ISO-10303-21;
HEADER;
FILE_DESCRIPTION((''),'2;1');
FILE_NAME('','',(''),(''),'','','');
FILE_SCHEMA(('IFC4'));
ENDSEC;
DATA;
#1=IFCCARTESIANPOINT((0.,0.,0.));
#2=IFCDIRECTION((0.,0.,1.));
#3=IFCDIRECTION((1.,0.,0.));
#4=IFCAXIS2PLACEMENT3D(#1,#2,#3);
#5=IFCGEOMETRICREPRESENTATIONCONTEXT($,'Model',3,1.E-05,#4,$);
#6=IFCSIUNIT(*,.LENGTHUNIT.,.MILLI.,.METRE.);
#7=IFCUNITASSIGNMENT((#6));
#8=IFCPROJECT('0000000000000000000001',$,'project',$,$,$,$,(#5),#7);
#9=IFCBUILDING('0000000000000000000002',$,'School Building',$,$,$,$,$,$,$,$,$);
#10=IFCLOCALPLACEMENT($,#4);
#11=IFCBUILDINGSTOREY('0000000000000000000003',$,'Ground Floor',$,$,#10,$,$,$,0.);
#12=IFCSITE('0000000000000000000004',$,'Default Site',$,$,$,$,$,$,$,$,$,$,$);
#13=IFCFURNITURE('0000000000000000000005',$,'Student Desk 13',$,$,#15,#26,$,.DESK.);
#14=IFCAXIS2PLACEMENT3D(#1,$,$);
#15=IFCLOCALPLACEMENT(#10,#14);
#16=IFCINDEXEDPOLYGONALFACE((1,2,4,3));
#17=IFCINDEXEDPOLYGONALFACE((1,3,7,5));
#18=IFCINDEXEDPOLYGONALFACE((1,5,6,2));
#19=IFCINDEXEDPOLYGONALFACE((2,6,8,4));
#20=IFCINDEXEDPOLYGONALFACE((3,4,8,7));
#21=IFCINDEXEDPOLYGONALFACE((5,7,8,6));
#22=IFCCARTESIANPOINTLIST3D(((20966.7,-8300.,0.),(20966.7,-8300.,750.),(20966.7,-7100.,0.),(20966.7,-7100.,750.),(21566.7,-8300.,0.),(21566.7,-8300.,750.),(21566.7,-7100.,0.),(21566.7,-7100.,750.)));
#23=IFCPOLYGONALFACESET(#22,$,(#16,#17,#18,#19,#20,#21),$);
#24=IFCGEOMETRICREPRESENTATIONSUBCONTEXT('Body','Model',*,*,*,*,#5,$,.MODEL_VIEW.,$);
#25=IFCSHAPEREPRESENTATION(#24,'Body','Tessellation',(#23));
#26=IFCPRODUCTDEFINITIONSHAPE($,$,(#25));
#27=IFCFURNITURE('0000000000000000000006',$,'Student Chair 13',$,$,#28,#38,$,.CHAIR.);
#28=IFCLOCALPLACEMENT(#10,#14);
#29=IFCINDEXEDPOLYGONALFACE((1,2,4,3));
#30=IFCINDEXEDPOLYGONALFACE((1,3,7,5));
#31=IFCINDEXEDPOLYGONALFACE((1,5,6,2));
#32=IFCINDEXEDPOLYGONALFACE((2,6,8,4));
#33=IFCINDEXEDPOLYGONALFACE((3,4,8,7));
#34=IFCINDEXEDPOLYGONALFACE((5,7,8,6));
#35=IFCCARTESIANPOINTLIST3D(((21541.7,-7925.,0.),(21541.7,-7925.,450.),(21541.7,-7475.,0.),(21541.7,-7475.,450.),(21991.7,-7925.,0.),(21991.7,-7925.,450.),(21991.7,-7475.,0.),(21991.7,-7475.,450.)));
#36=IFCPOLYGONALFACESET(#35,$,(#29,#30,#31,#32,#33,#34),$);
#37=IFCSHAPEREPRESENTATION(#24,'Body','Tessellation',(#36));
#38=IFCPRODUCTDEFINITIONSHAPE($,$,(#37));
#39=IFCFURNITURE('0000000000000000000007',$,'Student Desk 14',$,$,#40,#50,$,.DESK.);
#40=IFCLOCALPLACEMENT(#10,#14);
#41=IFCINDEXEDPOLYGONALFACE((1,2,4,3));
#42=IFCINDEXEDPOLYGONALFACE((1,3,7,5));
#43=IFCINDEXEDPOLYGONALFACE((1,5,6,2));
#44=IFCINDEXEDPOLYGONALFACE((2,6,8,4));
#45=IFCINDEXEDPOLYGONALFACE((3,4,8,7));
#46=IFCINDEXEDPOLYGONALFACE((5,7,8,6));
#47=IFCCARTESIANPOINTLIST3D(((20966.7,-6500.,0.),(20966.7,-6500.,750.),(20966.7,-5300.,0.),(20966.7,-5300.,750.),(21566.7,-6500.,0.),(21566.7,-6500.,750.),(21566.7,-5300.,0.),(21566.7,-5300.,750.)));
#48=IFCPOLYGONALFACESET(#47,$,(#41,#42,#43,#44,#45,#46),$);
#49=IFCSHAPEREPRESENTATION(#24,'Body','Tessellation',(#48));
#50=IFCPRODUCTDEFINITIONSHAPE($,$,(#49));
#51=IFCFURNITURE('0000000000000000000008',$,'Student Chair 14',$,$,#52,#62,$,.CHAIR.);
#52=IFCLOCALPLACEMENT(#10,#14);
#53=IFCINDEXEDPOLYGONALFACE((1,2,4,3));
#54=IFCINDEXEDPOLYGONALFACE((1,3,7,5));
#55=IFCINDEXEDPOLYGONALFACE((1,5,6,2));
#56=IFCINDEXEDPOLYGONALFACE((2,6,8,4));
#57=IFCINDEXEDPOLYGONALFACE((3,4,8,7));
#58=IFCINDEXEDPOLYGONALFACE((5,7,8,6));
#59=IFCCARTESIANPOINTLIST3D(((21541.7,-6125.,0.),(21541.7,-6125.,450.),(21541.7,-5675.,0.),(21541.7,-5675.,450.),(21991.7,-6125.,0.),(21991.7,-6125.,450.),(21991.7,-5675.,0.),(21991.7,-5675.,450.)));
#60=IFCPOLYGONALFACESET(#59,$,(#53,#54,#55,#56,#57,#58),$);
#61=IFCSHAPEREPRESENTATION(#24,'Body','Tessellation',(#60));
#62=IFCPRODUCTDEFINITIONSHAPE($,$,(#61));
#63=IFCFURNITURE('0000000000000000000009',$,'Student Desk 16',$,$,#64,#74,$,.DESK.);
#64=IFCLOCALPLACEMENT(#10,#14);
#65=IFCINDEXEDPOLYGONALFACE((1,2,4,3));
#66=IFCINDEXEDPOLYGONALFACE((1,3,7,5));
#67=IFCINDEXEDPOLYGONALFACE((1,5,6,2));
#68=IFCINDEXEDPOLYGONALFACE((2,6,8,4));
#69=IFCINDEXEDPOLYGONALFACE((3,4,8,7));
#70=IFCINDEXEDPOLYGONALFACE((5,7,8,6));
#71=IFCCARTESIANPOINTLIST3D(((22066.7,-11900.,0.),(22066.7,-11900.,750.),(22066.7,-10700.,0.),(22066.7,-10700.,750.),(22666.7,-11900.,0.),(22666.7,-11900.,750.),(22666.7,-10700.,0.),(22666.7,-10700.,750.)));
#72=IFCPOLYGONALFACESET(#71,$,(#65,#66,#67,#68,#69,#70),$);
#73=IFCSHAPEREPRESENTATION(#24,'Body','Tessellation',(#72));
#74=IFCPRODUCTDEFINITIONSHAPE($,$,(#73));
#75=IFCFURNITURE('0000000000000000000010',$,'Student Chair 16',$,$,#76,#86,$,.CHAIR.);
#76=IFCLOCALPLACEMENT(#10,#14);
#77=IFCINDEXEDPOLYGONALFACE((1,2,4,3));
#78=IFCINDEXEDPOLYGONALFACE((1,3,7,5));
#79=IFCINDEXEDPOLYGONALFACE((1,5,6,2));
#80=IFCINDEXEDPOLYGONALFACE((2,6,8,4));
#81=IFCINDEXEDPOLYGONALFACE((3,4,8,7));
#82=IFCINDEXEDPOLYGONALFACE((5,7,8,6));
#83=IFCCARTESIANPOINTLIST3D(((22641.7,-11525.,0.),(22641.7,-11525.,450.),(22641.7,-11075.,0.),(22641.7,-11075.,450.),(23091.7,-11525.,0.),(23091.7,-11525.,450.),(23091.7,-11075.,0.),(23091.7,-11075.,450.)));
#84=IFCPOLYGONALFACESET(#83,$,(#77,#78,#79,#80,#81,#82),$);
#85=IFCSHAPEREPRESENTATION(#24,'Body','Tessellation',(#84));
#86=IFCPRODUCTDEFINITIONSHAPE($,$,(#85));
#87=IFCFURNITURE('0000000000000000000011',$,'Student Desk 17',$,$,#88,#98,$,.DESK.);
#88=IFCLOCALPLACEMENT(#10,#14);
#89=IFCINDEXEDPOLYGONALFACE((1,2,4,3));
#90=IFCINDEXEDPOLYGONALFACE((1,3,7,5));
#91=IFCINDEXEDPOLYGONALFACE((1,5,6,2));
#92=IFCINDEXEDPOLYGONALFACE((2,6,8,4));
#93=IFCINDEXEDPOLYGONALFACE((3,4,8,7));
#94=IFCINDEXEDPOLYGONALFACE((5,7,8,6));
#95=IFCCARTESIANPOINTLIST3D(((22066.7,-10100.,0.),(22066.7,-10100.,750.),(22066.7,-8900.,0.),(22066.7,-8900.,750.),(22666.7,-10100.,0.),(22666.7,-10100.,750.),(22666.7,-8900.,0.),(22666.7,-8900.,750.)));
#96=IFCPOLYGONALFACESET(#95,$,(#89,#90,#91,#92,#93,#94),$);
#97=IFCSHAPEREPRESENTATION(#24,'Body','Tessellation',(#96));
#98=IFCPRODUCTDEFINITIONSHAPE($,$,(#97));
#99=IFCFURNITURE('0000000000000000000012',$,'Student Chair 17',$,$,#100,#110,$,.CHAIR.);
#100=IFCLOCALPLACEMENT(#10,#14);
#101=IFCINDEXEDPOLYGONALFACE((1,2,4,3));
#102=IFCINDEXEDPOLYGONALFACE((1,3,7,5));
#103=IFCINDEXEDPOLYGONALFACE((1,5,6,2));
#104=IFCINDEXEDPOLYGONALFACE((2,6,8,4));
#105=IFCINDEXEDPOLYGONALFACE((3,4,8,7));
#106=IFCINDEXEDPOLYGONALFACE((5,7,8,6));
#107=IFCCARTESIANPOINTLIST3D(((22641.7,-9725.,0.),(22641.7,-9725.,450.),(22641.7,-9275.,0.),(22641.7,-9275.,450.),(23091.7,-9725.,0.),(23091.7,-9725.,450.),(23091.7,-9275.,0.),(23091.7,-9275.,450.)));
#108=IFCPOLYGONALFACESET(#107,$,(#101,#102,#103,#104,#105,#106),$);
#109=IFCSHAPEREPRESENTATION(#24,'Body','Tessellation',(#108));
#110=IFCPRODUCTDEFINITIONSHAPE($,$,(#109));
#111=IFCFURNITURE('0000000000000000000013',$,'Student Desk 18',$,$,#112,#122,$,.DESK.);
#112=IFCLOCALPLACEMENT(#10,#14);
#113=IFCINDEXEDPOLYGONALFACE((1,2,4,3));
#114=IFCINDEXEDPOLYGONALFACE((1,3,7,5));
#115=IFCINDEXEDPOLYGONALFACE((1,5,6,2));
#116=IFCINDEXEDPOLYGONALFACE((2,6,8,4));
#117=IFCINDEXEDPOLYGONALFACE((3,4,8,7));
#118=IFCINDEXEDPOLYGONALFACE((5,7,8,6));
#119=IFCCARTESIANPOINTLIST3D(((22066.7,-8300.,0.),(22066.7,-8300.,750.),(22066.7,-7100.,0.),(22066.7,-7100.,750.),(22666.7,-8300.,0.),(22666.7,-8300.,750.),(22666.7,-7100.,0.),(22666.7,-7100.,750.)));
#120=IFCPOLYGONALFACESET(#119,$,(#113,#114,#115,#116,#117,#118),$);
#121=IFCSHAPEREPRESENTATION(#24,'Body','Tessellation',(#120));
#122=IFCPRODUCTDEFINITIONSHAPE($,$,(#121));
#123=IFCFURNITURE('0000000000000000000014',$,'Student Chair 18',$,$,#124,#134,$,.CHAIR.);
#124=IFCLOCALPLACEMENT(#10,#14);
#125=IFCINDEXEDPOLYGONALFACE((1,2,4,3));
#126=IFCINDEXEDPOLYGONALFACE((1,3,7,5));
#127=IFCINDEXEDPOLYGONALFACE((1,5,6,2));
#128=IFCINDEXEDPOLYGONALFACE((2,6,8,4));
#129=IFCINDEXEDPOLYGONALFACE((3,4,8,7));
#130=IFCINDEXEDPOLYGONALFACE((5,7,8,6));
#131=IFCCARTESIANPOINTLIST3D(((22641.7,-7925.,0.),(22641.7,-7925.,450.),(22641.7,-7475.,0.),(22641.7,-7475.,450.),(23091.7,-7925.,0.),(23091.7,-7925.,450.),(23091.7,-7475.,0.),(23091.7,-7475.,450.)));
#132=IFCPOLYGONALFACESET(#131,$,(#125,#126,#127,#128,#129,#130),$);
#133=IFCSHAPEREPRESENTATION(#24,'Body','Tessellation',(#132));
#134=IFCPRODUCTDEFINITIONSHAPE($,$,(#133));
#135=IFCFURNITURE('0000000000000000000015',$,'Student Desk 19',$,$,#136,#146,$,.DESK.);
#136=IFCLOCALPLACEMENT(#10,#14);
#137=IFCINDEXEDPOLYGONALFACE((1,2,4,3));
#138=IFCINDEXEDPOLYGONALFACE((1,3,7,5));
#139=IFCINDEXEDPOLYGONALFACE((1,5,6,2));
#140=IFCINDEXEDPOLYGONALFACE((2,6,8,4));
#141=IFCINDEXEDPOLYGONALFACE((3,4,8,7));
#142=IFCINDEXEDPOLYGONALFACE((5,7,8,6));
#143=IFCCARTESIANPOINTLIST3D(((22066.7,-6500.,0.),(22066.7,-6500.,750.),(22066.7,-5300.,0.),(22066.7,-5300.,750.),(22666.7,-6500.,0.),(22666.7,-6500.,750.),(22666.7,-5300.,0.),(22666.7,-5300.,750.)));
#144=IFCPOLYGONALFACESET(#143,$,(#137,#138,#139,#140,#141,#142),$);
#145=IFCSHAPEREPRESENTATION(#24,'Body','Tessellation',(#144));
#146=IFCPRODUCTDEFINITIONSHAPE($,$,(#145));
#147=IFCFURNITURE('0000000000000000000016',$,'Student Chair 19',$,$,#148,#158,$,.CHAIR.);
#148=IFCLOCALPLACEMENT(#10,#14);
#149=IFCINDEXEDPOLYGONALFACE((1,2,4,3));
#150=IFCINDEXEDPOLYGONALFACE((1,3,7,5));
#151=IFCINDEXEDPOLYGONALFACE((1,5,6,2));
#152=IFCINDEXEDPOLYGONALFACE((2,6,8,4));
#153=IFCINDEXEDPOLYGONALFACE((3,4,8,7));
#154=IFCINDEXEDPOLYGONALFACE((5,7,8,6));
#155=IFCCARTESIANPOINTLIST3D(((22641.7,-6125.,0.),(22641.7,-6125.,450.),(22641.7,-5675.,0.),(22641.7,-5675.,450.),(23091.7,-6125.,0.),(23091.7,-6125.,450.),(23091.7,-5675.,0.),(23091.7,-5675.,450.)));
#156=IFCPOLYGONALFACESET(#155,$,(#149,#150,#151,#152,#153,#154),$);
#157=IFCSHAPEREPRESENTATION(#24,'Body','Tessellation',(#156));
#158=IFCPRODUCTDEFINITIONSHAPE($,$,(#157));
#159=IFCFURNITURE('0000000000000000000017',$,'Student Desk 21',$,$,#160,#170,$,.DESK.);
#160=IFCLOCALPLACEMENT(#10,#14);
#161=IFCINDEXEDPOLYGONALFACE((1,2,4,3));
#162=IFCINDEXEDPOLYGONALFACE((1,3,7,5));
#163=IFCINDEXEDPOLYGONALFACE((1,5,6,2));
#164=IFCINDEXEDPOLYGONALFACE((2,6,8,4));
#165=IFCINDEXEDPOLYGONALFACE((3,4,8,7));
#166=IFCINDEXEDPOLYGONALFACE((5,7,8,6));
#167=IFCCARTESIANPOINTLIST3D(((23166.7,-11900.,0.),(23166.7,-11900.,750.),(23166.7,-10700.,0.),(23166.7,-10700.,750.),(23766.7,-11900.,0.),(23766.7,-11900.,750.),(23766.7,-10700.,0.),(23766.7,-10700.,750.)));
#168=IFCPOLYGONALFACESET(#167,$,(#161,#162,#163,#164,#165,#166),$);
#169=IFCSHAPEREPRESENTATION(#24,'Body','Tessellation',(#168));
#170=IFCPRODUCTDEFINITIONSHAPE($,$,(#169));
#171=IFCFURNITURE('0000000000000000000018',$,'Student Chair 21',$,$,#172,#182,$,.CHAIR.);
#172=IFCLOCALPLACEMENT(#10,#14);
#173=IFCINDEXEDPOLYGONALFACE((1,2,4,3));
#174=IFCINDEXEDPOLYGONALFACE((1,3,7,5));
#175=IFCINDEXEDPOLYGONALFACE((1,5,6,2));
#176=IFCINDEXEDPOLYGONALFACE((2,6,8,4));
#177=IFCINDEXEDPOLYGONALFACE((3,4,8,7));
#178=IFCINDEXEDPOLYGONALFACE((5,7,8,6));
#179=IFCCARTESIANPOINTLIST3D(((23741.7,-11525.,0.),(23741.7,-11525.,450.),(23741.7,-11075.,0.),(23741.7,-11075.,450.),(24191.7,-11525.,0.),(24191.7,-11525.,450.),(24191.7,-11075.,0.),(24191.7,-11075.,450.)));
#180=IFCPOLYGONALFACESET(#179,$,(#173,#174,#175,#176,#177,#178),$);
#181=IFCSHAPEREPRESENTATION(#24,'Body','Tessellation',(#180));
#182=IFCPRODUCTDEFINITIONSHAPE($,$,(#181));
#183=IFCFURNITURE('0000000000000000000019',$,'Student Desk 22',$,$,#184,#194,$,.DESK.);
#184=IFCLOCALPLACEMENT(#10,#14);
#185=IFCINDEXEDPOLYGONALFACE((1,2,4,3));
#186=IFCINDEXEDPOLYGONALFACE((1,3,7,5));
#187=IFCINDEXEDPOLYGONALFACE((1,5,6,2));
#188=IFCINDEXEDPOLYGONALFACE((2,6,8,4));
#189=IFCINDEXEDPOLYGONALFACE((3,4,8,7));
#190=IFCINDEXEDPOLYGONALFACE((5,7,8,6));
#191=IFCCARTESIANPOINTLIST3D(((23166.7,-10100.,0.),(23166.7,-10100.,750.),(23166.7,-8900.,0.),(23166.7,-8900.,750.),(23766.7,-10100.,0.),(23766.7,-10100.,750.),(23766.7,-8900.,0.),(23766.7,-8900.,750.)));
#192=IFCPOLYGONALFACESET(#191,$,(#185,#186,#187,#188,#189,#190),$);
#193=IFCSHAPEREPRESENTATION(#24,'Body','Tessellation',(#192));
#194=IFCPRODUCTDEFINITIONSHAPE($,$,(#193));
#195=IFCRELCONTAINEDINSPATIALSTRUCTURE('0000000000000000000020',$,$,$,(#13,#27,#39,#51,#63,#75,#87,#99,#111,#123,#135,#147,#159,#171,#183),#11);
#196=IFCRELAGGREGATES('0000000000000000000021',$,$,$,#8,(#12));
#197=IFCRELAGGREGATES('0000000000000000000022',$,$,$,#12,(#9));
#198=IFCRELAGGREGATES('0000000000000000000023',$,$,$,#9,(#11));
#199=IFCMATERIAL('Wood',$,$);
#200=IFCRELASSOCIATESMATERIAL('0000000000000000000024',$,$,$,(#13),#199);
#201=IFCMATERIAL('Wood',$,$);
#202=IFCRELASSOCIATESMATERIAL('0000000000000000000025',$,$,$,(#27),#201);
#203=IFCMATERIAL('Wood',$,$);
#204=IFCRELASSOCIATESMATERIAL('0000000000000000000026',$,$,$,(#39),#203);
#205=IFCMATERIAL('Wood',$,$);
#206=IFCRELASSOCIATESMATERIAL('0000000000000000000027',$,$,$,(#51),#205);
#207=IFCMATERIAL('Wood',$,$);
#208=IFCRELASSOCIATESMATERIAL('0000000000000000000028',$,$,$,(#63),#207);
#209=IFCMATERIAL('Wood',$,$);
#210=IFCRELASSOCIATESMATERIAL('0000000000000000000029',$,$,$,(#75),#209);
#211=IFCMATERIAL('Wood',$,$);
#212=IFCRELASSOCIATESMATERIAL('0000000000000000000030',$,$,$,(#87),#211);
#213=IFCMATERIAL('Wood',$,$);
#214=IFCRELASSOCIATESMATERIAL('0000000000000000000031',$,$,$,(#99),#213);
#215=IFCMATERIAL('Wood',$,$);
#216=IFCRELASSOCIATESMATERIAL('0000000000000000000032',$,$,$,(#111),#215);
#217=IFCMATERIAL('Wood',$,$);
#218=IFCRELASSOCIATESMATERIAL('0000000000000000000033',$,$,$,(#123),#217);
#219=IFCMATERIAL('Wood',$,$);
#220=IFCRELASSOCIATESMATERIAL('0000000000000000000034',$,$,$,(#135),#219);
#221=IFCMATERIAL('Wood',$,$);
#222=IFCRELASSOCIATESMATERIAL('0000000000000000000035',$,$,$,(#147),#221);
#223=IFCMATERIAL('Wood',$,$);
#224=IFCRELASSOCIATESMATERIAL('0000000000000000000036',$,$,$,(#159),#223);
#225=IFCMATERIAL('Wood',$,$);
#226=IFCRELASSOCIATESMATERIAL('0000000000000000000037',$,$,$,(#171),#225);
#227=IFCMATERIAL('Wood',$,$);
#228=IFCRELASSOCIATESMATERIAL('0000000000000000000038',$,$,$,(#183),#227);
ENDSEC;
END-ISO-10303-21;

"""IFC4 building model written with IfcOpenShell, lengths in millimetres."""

from ifc_helpers import new_model, si_unit, frame, origin_with_axes, origin_2d, place, context, subcontext, project, spatial, rectangle, extrude, material, element, save


model = new_model("IFC4")

# Units and contexts
model_context = context("Model", 3, precision=1e-05, world=origin_with_axes())
body_context = subcontext(model_context, "Body", "Model", "MODEL_VIEW")
ifc_project = project(units=[si_unit("LENGTHUNIT", "METRE", prefix="MILLI")], contexts=[model_context])

# Site, building, storey
site = spatial("IfcSite", under=ifc_project, Name="Default Site")
building = spatial("IfcBuilding", under=site, Name="School Building")
storey_placement = place(None, origin_with_axes())
storey = spatial("IfcBuildingStorey", under=building, at=storey_placement, Name="Ground Floor", Elevation=0.0)

# Furniture
ifc_material_1 = material(Name="Wood")
furniture_1_placement = place(storey_placement, frame((21266.7, -7700.0, 0.0), z_axis=(0.0, 0.0, 1.0), x_axis=(0.0, 1.0, 0.0)))
element("IfcFurniture", 1, at=furniture_1_placement, inside=storey, material=ifc_material_1, Name="Student Desk 13", PredefinedType="DESK", context=body_context, shape_type="SweptSolid", body=[
    extrude(rectangle(XDim=1200.0, YDim=600.0, at=origin_2d()), origin_with_axes(), (0.0, 0.0, 1.0), 750.0),
])
ifc_material_2 = material(Name="Wood")
furniture_2_placement = place(storey_placement, frame((21766.7, -7700.0, 0.0), z_axis=(0.0, 0.0, 1.0), x_axis=(1.0, 0.0, 0.0)))
element("IfcFurniture", 2, at=furniture_2_placement, inside=storey, material=ifc_material_2, Name="Student Chair 13", PredefinedType="CHAIR", context=body_context, shape_type="SweptSolid", body=[
    extrude(rectangle(XDim=450.0, YDim=450.0, at=origin_2d()), origin_with_axes(), (0.0, 0.0, 1.0), 450.0),
])
ifc_material_3 = material(Name="Wood")
furniture_3_placement = place(storey_placement, frame((21266.7, -5900.0, 0.0), z_axis=(0.0, 0.0, 1.0), x_axis=(0.0, 1.0, 0.0)))
element("IfcFurniture", 3, at=furniture_3_placement, inside=storey, material=ifc_material_3, Name="Student Desk 14", PredefinedType="DESK", context=body_context, shape_type="SweptSolid", body=[
    extrude(rectangle(XDim=1200.0, YDim=600.0, at=origin_2d()), origin_with_axes(), (0.0, 0.0, 1.0), 750.0),
])
ifc_material_4 = material(Name="Wood")
furniture_4_placement = place(storey_placement, frame((21766.7, -5900.0, 0.0), z_axis=(0.0, 0.0, 1.0), x_axis=(1.0, 0.0, 0.0)))
element("IfcFurniture", 4, at=furniture_4_placement, inside=storey, material=ifc_material_4, Name="Student Chair 14", PredefinedType="CHAIR", context=body_context, shape_type="SweptSolid", body=[
    extrude(rectangle(XDim=450.0, YDim=450.0, at=origin_2d()), origin_with_axes(), (0.0, 0.0, 1.0), 450.0),
])
ifc_material_5 = material(Name="Wood")
furniture_5_placement = place(storey_placement, frame((22366.7, -11300.0, 0.0), z_axis=(0.0, 0.0, 1.0), x_axis=(0.0, 1.0, 0.0)))
element("IfcFurniture", 5, at=furniture_5_placement, inside=storey, material=ifc_material_5, Name="Student Desk 16", PredefinedType="DESK", context=body_context, shape_type="SweptSolid", body=[
    extrude(rectangle(XDim=1200.0, YDim=600.0, at=origin_2d()), origin_with_axes(), (0.0, 0.0, 1.0), 750.0),
])
ifc_material_6 = material(Name="Wood")
furniture_6_placement = place(storey_placement, frame((22866.7, -11300.0, 0.0), z_axis=(0.0, 0.0, 1.0), x_axis=(1.0, 0.0, 0.0)))
element("IfcFurniture", 6, at=furniture_6_placement, inside=storey, material=ifc_material_6, Name="Student Chair 16", PredefinedType="CHAIR", context=body_context, shape_type="SweptSolid", body=[
    extrude(rectangle(XDim=450.0, YDim=450.0, at=origin_2d()), origin_with_axes(), (0.0, 0.0, 1.0), 450.0),
])
ifc_material_7 = material(Name="Wood")
furniture_7_placement = place(storey_placement, frame((22366.7, -9500.0, 0.0), z_axis=(0.0, 0.0, 1.0), x_axis=(0.0, 1.0, 0.0)))
element("IfcFurniture", 7, at=furniture_7_placement, inside=storey, material=ifc_material_7, Name="Student Desk 17", PredefinedType="DESK", context=body_context, shape_type="SweptSolid", body=[
    extrude(rectangle(XDim=1200.0, YDim=600.0, at=origin_2d()), origin_with_axes(), (0.0, 0.0, 1.0), 750.0),
])
ifc_material_8 = material(Name="Wood")
furniture_8_placement = place(storey_placement, frame((22866.7, -9500.0, 0.0), z_axis=(0.0, 0.0, 1.0), x_axis=(1.0, 0.0, 0.0)))
element("IfcFurniture", 8, at=furniture_8_placement, inside=storey, material=ifc_material_8, Name="Student Chair 17", PredefinedType="CHAIR", context=body_context, shape_type="SweptSolid", body=[
    extrude(rectangle(XDim=450.0, YDim=450.0, at=origin_2d()), origin_with_axes(), (0.0, 0.0, 1.0), 450.0),
])
ifc_material_9 = material(Name="Wood")
furniture_9_placement = place(storey_placement, frame((22366.7, -7700.0, 0.0), z_axis=(0.0, 0.0, 1.0), x_axis=(0.0, 1.0, 0.0)))
element("IfcFurniture", 9, at=furniture_9_placement, inside=storey, material=ifc_material_9, Name="Student Desk 18", PredefinedType="DESK", context=body_context, shape_type="SweptSolid", body=[
    extrude(rectangle(XDim=1200.0, YDim=600.0, at=origin_2d()), origin_with_axes(), (0.0, 0.0, 1.0), 750.0),
])
ifc_material_10 = material(Name="Wood")
furniture_10_placement = place(storey_placement, frame((22866.7, -7700.0, 0.0), z_axis=(0.0, 0.0, 1.0), x_axis=(1.0, 0.0, 0.0)))
element("IfcFurniture", 10, at=furniture_10_placement, inside=storey, material=ifc_material_10, Name="Student Chair 18", PredefinedType="CHAIR", context=body_context, shape_type="SweptSolid", body=[
    extrude(rectangle(XDim=450.0, YDim=450.0, at=origin_2d()), origin_with_axes(), (0.0, 0.0, 1.0), 450.0),
])
ifc_material_11 = material(Name="Wood")
furniture_11_placement = place(storey_placement, frame((22366.7, -5900.0, 0.0), z_axis=(0.0, 0.0, 1.0), x_axis=(0.0, 1.0, 0.0)))
element("IfcFurniture", 11, at=furniture_11_placement, inside=storey, material=ifc_material_11, Name="Student Desk 19", PredefinedType="DESK", context=body_context, shape_type="SweptSolid", body=[
    extrude(rectangle(XDim=1200.0, YDim=600.0, at=origin_2d()), origin_with_axes(), (0.0, 0.0, 1.0), 750.0),
])
ifc_material_12 = material(Name="Wood")
furniture_12_placement = place(storey_placement, frame((22866.7, -5900.0, 0.0), z_axis=(0.0, 0.0, 1.0), x_axis=(1.0, 0.0, 0.0)))
element("IfcFurniture", 12, at=furniture_12_placement, inside=storey, material=ifc_material_12, Name="Student Chair 19", PredefinedType="CHAIR", context=body_context, shape_type="SweptSolid", body=[
    extrude(rectangle(XDim=450.0, YDim=450.0, at=origin_2d()), origin_with_axes(), (0.0, 0.0, 1.0), 450.0),
])
ifc_material_13 = material(Name="Wood")
furniture_13_placement = place(storey_placement, frame((23466.7, -11300.0, 0.0), z_axis=(0.0, 0.0, 1.0), x_axis=(0.0, 1.0, 0.0)))
element("IfcFurniture", 13, at=furniture_13_placement, inside=storey, material=ifc_material_13, Name="Student Desk 21", PredefinedType="DESK", context=body_context, shape_type="SweptSolid", body=[
    extrude(rectangle(XDim=1200.0, YDim=600.0, at=origin_2d()), origin_with_axes(), (0.0, 0.0, 1.0), 750.0),
])
ifc_material_14 = material(Name="Wood")
furniture_14_placement = place(storey_placement, frame((23966.7, -11300.0, 0.0), z_axis=(0.0, 0.0, 1.0), x_axis=(1.0, 0.0, 0.0)))
element("IfcFurniture", 14, at=furniture_14_placement, inside=storey, material=ifc_material_14, Name="Student Chair 21", PredefinedType="CHAIR", context=body_context, shape_type="SweptSolid", body=[
    extrude(rectangle(XDim=450.0, YDim=450.0, at=origin_2d()), origin_with_axes(), (0.0, 0.0, 1.0), 450.0),
])
ifc_material_15 = material(Name="Wood")
furniture_15_placement = place(storey_placement, frame((23466.7, -9500.0, 0.0), z_axis=(0.0, 0.0, 1.0), x_axis=(0.0, 1.0, 0.0)))
element("IfcFurniture", 15, at=furniture_15_placement, inside=storey, material=ifc_material_15, Name="Student Desk 22", PredefinedType="DESK", context=body_context, shape_type="SweptSolid", body=[
    extrude(rectangle(XDim=1200.0, YDim=600.0, at=origin_2d()), origin_with_axes(), (0.0, 0.0, 1.0), 750.0),
])

save(model, "model.ifc")
